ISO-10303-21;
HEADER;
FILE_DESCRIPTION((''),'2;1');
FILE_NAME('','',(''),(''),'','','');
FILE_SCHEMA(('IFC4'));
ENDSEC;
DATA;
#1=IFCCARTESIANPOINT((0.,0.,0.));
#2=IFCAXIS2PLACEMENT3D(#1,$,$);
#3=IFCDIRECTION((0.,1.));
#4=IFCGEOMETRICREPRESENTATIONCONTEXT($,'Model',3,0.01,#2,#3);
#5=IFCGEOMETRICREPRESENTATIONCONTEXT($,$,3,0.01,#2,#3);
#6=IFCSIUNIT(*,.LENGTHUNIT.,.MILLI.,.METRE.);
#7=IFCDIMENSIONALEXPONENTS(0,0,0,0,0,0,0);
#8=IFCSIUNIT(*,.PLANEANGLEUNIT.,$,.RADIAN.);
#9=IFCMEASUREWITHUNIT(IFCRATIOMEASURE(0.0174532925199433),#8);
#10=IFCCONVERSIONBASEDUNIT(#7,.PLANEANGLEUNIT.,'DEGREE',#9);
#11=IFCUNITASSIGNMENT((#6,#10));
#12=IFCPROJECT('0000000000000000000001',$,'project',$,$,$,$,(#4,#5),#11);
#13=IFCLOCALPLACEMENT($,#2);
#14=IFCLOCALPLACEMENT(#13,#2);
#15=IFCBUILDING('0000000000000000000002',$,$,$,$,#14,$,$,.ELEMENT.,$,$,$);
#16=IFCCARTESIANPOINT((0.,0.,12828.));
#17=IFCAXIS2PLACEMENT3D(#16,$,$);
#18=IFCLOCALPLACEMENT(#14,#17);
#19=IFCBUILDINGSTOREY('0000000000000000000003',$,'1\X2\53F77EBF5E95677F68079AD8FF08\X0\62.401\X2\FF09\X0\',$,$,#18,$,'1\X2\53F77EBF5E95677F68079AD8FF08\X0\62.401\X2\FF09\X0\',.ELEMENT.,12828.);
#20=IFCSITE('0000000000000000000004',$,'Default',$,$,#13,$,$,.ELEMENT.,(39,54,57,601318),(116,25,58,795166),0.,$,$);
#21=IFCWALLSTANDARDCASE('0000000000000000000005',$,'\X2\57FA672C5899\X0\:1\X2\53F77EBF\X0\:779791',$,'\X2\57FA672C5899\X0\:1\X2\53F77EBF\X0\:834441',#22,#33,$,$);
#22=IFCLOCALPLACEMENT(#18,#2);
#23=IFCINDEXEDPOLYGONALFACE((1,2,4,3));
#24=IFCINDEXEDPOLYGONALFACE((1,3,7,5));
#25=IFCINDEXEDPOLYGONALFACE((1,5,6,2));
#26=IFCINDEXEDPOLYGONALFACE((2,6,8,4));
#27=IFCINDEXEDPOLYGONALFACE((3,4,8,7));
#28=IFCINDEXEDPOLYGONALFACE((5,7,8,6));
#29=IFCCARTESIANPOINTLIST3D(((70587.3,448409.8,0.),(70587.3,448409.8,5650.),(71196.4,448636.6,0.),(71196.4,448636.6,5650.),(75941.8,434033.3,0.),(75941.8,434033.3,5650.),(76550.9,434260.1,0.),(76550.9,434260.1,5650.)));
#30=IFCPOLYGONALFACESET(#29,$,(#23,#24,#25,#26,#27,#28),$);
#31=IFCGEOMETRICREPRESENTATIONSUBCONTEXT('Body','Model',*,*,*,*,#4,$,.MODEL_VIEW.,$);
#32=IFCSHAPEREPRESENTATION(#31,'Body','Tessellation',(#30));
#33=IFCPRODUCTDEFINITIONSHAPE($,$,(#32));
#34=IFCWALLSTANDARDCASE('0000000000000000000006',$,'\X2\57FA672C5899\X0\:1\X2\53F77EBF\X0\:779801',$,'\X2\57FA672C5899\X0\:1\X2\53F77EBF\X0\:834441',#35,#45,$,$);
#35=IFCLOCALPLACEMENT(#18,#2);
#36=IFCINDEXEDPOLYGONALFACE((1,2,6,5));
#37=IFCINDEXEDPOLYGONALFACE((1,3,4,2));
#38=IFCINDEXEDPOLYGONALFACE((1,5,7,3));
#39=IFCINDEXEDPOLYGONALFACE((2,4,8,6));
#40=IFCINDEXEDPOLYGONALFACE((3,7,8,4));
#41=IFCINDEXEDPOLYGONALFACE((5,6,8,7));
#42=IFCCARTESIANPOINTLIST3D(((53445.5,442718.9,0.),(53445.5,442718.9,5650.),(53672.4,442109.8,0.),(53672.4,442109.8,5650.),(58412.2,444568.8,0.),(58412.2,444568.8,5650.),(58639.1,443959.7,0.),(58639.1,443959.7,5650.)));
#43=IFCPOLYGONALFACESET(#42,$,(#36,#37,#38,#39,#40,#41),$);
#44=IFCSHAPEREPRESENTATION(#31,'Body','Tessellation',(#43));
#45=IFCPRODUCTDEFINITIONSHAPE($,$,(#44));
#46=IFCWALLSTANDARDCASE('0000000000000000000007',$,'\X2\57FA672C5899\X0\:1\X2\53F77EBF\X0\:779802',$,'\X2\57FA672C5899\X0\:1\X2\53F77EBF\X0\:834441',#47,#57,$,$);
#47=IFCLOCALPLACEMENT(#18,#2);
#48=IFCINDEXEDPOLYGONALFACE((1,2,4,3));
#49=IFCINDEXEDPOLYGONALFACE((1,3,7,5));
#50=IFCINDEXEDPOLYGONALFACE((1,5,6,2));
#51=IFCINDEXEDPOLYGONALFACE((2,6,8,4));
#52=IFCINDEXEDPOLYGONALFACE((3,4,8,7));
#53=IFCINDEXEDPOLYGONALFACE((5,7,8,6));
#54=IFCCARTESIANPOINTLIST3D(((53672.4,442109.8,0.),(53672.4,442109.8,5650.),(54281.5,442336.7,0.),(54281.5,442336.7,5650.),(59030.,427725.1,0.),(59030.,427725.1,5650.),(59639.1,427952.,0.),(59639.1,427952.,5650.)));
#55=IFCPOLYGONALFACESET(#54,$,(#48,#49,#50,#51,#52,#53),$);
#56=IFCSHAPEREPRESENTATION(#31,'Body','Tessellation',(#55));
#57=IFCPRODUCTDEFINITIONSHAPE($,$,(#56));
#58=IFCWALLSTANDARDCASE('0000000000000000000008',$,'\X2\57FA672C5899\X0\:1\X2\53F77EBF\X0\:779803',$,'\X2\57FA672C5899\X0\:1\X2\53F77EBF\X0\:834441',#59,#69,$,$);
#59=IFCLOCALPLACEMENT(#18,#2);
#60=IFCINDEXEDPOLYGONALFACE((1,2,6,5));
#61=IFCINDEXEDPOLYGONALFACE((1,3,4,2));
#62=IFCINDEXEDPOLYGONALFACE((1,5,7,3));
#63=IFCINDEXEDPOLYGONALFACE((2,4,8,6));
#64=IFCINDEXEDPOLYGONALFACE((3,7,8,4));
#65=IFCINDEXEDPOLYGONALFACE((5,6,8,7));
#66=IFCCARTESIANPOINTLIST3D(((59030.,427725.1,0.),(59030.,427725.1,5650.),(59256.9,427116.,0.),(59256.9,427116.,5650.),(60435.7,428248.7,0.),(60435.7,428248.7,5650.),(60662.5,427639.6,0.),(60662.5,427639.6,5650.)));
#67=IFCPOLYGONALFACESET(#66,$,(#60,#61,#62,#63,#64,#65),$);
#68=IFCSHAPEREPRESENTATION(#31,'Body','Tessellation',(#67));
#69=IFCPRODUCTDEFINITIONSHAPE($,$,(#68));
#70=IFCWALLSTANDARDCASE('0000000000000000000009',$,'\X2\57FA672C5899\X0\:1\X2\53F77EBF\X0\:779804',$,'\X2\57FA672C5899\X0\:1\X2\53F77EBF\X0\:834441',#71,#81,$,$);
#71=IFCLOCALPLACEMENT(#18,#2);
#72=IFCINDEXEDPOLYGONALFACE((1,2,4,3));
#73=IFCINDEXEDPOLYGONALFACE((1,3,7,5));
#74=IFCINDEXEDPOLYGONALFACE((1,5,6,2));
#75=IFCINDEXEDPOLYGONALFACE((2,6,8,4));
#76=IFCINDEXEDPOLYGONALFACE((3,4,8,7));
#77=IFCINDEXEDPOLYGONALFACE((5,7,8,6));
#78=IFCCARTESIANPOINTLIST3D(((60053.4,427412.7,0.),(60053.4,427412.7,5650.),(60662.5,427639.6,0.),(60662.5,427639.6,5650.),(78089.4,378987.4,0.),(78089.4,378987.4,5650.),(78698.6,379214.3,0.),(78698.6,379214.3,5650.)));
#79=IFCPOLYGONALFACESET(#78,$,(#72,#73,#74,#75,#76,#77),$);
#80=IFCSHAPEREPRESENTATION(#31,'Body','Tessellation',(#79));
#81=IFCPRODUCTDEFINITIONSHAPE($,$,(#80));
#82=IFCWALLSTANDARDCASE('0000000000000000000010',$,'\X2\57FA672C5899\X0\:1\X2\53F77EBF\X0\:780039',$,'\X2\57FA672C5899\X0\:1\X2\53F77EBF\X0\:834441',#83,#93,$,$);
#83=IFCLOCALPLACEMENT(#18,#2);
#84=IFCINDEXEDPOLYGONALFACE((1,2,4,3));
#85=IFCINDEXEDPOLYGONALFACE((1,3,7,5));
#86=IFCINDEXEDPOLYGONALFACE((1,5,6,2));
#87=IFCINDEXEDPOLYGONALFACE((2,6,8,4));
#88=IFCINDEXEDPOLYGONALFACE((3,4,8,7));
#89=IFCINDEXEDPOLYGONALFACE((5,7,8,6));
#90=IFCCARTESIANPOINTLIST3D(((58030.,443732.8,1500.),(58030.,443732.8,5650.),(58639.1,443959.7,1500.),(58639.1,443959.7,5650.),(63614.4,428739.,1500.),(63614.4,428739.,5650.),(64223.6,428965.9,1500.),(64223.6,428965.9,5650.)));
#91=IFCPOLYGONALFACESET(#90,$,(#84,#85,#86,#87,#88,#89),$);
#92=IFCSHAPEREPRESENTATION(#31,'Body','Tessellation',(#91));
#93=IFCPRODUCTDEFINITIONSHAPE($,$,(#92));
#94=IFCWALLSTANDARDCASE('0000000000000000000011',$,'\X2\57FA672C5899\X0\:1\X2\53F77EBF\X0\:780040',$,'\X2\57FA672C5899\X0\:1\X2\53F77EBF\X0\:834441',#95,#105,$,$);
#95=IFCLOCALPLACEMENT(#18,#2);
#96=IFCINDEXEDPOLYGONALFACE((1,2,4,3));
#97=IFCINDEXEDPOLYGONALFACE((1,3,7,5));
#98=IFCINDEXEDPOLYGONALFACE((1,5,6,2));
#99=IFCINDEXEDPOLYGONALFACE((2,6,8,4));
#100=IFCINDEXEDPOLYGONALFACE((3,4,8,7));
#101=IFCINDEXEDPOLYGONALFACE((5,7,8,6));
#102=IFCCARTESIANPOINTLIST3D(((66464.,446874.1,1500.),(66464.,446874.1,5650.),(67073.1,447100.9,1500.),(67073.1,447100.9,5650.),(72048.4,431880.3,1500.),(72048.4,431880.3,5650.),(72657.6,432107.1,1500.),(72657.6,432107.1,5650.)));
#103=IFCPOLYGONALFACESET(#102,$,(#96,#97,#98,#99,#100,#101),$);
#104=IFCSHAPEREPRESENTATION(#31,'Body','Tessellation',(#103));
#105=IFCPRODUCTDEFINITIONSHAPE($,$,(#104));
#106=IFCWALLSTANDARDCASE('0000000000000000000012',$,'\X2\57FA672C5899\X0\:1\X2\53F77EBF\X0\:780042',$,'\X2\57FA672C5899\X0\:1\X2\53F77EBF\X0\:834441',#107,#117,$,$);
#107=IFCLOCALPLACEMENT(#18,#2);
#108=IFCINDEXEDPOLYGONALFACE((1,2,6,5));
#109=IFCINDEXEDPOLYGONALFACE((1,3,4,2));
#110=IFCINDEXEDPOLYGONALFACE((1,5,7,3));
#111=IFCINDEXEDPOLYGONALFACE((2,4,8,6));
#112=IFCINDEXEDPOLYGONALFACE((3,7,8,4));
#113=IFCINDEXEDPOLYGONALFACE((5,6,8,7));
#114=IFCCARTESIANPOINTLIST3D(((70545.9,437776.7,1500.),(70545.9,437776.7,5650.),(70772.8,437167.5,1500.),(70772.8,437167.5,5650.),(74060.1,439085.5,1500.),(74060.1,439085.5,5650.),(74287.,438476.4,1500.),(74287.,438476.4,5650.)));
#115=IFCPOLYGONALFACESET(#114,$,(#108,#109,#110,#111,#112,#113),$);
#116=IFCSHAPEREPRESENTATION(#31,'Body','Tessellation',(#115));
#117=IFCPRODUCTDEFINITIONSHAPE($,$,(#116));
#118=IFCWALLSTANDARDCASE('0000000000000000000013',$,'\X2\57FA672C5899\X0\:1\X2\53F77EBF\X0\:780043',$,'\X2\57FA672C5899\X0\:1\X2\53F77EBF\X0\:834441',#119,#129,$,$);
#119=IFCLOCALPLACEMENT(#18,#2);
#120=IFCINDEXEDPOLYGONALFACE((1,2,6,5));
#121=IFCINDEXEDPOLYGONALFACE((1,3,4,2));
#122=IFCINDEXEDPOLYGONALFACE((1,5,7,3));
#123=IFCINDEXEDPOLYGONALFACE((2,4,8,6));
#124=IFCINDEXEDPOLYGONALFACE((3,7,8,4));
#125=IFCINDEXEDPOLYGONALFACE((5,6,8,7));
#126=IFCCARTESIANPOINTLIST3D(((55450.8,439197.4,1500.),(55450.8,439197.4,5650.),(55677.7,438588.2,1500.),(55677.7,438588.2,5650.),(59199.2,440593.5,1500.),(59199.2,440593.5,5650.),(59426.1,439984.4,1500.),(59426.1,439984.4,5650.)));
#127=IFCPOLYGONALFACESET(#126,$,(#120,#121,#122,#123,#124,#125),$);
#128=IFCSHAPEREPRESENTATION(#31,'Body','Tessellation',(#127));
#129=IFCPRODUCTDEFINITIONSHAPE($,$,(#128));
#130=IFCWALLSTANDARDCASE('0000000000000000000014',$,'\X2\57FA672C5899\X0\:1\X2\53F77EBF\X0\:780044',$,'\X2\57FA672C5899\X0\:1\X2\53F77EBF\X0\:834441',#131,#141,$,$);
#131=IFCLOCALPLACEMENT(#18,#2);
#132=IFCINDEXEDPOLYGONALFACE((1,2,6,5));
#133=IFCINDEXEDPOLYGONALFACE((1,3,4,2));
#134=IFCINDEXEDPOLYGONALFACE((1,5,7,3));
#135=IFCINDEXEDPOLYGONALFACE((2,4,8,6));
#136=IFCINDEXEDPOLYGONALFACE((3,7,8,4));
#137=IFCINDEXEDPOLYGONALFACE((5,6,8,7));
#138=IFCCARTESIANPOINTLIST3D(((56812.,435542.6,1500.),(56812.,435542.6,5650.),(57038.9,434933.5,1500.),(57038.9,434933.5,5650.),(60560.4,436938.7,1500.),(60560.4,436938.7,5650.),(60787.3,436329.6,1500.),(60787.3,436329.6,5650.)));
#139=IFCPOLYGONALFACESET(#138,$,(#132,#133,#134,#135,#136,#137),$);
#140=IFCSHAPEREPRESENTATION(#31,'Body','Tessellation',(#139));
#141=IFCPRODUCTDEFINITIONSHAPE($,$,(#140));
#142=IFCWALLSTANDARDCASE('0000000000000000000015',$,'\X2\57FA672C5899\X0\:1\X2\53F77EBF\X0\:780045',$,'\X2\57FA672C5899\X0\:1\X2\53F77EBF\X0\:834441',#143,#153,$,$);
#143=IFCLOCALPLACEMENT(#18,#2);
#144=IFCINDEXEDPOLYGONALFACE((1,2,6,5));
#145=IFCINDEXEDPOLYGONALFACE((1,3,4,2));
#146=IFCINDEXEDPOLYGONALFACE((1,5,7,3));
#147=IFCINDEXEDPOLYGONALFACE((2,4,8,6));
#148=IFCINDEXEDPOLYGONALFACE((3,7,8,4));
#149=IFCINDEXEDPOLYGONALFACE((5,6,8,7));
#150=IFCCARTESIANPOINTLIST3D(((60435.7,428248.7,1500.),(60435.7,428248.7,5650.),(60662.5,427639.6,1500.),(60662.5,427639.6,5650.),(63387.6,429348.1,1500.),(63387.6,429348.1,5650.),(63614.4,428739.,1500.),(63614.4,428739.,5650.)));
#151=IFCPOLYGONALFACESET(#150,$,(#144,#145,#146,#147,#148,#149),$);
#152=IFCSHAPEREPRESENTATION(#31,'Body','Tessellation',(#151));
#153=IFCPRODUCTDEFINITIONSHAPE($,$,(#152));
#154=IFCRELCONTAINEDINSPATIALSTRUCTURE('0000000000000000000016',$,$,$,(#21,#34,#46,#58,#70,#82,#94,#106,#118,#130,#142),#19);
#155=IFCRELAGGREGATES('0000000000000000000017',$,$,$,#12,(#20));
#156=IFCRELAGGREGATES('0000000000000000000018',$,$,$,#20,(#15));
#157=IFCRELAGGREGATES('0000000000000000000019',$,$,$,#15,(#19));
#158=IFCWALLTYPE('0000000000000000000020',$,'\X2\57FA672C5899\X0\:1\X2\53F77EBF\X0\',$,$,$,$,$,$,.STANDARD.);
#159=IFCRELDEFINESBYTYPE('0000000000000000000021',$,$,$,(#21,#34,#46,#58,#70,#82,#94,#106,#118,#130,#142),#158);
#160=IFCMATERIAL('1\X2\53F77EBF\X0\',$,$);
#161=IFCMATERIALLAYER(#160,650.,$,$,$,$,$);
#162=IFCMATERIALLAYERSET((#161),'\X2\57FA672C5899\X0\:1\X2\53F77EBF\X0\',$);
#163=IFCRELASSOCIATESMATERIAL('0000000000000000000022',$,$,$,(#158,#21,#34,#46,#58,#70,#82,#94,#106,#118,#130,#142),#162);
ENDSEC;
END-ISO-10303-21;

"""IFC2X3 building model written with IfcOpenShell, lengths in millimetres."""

from ifc_helpers import new_model, entity, si_unit, converted_unit, direction, frame, frame_2d, origin, place, context, subcontext, project, spatial, polyline, rectangle, extrude, clip, bounded_halfspace, material, layer, layer_set, layer_usage, type_object, element, save


model = new_model("IFC2X3")

# Units and contexts
model_context = context("Model", 3, precision=0.01, world=origin(), true_north=direction((0.0, 1.0)))
context_of_model = context(None, 3, precision=0.01, world=origin(), true_north=direction((0.0, 1.0)))
body_context = subcontext(model_context, "Body", "Model", "MODEL_VIEW")
ifc_project = project(units=[si_unit("LENGTHUNIT", "METRE", prefix="MILLI"), converted_unit("PLANEANGLEUNIT", "DEGREE", entity("IfcRatioMeasure", 0.0174532925199433), si_unit("PLANEANGLEUNIT", "RADIAN"), dimensions=[0, 0, 0, 0, 0, 0, 0])], contexts=[model_context, context_of_model])

# Site, building, storey
site_placement = place(None, origin())
site = spatial("IfcSite", under=ifc_project, at=site_placement, Name="Default", CompositionType="ELEMENT", RefLatitude=(39, 54, 57, 601318), RefLongitude=(116, 25, 58, 795166), RefElevation=0.0)
building_placement = place(site_placement, origin())
building = spatial("IfcBuilding", under=site, at=building_placement, CompositionType="ELEMENT")
storey_placement = place(building_placement, frame((0.0, 0.0, 12828.0)))
storey = spatial("IfcBuildingStorey", under=building, at=storey_placement, Name="1号线底板标高（62.401）", LongName="1号线底板标高（62.401）", CompositionType="ELEMENT", Elevation=12828.0)

# Walls
ifc_material_1 = material(Name="1号线")
ifc_layer_1 = layer(ifc_material_1, 650.0)
ifc_layer_set_1 = layer_set([ifc_layer_1], Name="基本墙:1号线")
wall_type = type_object("IfcWallType", Name="基本墙:1号线", PredefinedType="STANDARD", material=ifc_layer_set_1)
ifc_layer_usage_1 = layer_usage(ifc_layer_set_1, "AXIS2", "NEGATIVE", 325.0)
wall_1_placement = place(storey_placement, frame((70891.9, 448523.2, 0.0), z_axis=(0.0, 0.0, 1.0), x_axis=(0.349028, -0.937112, 0.0)))
element("IfcWallStandardCase", 1, at=wall_1_placement, inside=storey, type_object=wall_type, material=ifc_layer_usage_1, Name="基本墙:1号线:779791", ObjectType="基本墙:1号线:834441", context=body_context, shape_type="Clipping", body=[
    clip(extrude(rectangle(XDim=15341.3, YDim=650.0, at=frame_2d((7670.6, 0.0), x_axis=(-1.0, 0.0))), origin(), (0.0, 0.0, 1.0), 5650.0), bounded_halfspace(frame((0.0, -325.0, 5650.0), z_axis=(0.0, 0.0, -1.0), x_axis=(0.0, 1.0, 0.0)), True, frame((0.0, -325.0, 5650.0)), polyline([(0.0, 0.0), (9950.0, 0.0), (10600.0, 0.0), (15341.3, 0.0), (15341.3, 650.0), (0.0, 650.0), (0.0, 0.0)]))),
])
ifc_layer_usage_2 = layer_usage(ifc_layer_set_1, "AXIS2", "NEGATIVE", 325.0)
wall_2_placement = place(storey_placement, frame((58525.7, 444264.2, 0.0), z_axis=(0.0, 0.0, 1.0), x_axis=(-0.937112, -0.349028, 0.0)))
element("IfcWallStandardCase", 2, at=wall_2_placement, inside=storey, type_object=wall_type, material=ifc_layer_usage_2, Name="基本墙:1号线:779801", ObjectType="基本墙:1号线:834441", context=body_context, shape_type="Clipping", body=[
    clip(extrude(rectangle(XDim=5300.0, YDim=650.0, at=frame_2d((2650.0, 0.0), x_axis=(-1.0, 0.0))), origin(), (0.0, 0.0, 1.0), 5650.0), bounded_halfspace(frame((0.0, -325.0, 5650.0), z_axis=(0.0, 0.0, -1.0), x_axis=(-1.0, 0.0, 0.0)), True, frame((0.0, -325.0, 5650.0)), polyline([(0.0, 0.0), (1950.5, 0.0), (5300.0, 0.0), (5300.0, 650.0), (4650.0, 650.0), (650.0, 650.0), (0.0, 650.0), (0.0, 0.0)]))),
])
ifc_layer_usage_3 = layer_usage(ifc_layer_set_1, "AXIS2", "NEGATIVE", 325.0)
wall_3_placement = place(storey_placement, frame((53977.0, 442223.3, 0.0), z_axis=(0.0, 0.0, 1.0), x_axis=(0.349028, -0.937112, 0.0)))
element("IfcWallStandardCase", 3, at=wall_3_placement, inside=storey, type_object=wall_type, material=ifc_layer_usage_3, Name="基本墙:1号线:779802", ObjectType="基本墙:1号线:834441", context=body_context, shape_type="Clipping", body=[
    clip(extrude(rectangle(XDim=15350.0, YDim=650.0, at=frame_2d((7675.0, 0.0), x_axis=(-1.0, 0.0))), origin(), (0.0, 0.0, 1.0), 5650.0), bounded_halfspace(frame((0.0, -325.0, 5650.0), z_axis=(0.0, 0.0, -1.0), x_axis=(0.0, 1.0, 0.0)), True, frame((0.0, -325.0, 5650.0)), polyline([(0.0, 0.0), (15350.0, 0.0), (15350.0, 650.0), (7900.0, 650.0), (7250.0, 650.0), (4000.0, 650.0), (3350.0, 650.0), (0.0, 650.0), (0.0, 0.0)]))),
])
ifc_layer_usage_4 = layer_usage(ifc_layer_set_1, "AXIS2", "NEGATIVE", 325.0)
wall_4_placement = place(storey_placement, frame((59143.4, 427420.6, 0.0), z_axis=(0.0, 0.0, 1.0), x_axis=(0.937112, 0.349028, 0.0)))
element("IfcWallStandardCase", 4, at=wall_4_placement, inside=storey, type_object=wall_type, material=ifc_layer_usage_4, Name="基本墙:1号线:779803", ObjectType="基本墙:1号线:834441", context=body_context, shape_type="Clipping", body=[
    clip(extrude(rectangle(XDim=1500.0, YDim=650.0, at=frame_2d((750.0, 0.0), x_axis=(-1.0, 0.0))), origin(), (0.0, 0.0, 1.0), 5650.0), bounded_halfspace(frame((0.0, -325.0, 5650.0), z_axis=(0.0, 0.0, -1.0), x_axis=(1.0, 0.0, 0.0)), True, frame((0.0, -325.0, 5650.0)), polyline([(0.0, 0.0), (650.0, 0.0), (850.0, 0.0), (1500.0, 0.0), (1500.0, 650.0), (650.0, 650.0), (0.0, 650.0), (0.0, 0.0)]))),
])
ifc_layer_usage_5 = layer_usage(ifc_layer_set_1, "AXIS2", "NEGATIVE", 325.0)
wall_5_placement = place(storey_placement, frame((60358.0, 427526.1, 0.0), z_axis=(0.0, 0.0, 1.0), x_axis=(0.349028, -0.937112, 0.0)))
element("IfcWallStandardCase", 5, at=wall_5_placement, inside=storey, type_object=wall_type, material=ifc_layer_usage_5, Name="基本墙:1号线:779804", ObjectType="基本墙:1号线:834441", context=body_context, shape_type="Clipping", body=[
    clip(extrude(rectangle(XDim=51675.0, YDim=650.0, at=frame_2d((25837.5, 0.0), x_axis=(-1.0, 0.0))), origin(), (0.0, 0.0, 1.0), 5650.0), bounded_halfspace(frame((0.0, -325.0, 5650.0), z_axis=(0.0, 0.0, -1.0), x_axis=(0.0, 1.0, 0.0)), True, frame((0.0, -325.0, 5650.0)), polyline([(0.0, 0.0), (200.0, 0.0), (50867.2, 0.0), (51023.8, 0.0), (51021.9, 650.0), (0.0, 650.0), (0.0, 0.0)]))),
])
ifc_layer_usage_6 = layer_usage(ifc_layer_set_1, "AXIS2", "NEGATIVE", 325.0)
wall_6_placement = place(storey_placement, frame((58334.5, 443846.2, 1500.0), z_axis=(0.0, 0.0, 1.0), x_axis=(0.349028, -0.937112, 0.0)))
element("IfcWallStandardCase", 6, at=wall_6_placement, inside=storey, type_object=wall_type, material=ifc_layer_usage_6, Name="基本墙:1号线:780039", ObjectType="基本墙:1号线:834441", context=body_context, shape_type="Clipping", body=[
    clip(extrude(rectangle(XDim=16000.0, YDim=650.0, at=frame_2d((8000.0, 0.0), x_axis=(-1.0, 0.0))), origin(), (0.0, 0.0, 1.0), 4150.0), bounded_halfspace(frame((0.0, -325.0, 4150.0), z_axis=(0.0, 0.0, -1.0), x_axis=(0.0, 1.0, 0.0)), True, frame((0.0, -325.0, 4150.0)), polyline([(0.0, 0.0), (3350.0, 0.0), (4000.0, 0.0), (7250.0, 0.0), (7900.0, 0.0), (15350.0, 0.0), (16000.0, 0.0), (16000.0, 650.0), (0.0, 650.0), (0.0, 0.0)]))),
])
ifc_layer_usage_7 = layer_usage(ifc_layer_set_1, "AXIS2", "NEGATIVE", 325.0)
wall_7_placement = place(storey_placement, frame((66768.6, 446987.5, 1500.0), z_axis=(0.0, 0.0, 1.0), x_axis=(0.349028, -0.937112, 0.0)))
element("IfcWallStandardCase", 7, at=wall_7_placement, inside=storey, type_object=wall_type, material=ifc_layer_usage_7, Name="基本墙:1号线:780040", ObjectType="基本墙:1号线:834441", context=body_context, shape_type="Clipping", body=[
    clip(extrude(rectangle(XDim=16000.0, YDim=650.0, at=frame_2d((8000.0, 0.0), x_axis=(-1.0, 0.0))), origin(), (0.0, 0.0, 1.0), 4150.0), bounded_halfspace(frame((0.0, -325.0, 4150.0), z_axis=(0.0, 0.0, -1.0), x_axis=(0.0, 1.0, 0.0)), True, frame((0.0, -325.0, 4150.0)), polyline([(0.0, 0.0), (16000.0, 0.0), (16000.0, 650.0), (15350.0, 650.0), (10600.0, 650.0), (9950.0, 650.0), (0.0, 650.0), (0.0, 0.0)]))),
])
ifc_layer_usage_8 = layer_usage(ifc_layer_set_1, "AXIS2", "NEGATIVE", 325.0)
wall_8_placement = place(storey_placement, frame((70659.4, 437472.1, 1500.0), z_axis=(0.0, 0.0, 1.0), x_axis=(0.937112, 0.349028, 0.0)))
element("IfcWallStandardCase", 8, at=wall_8_placement, inside=storey, type_object=wall_type, material=ifc_layer_usage_8, Name="基本墙:1号线:780042", ObjectType="基本墙:1号线:834441", context=body_context, shape_type="Clipping", body=[
    clip(extrude(rectangle(XDim=3750.0, YDim=650.0, at=frame_2d((1875.0, 0.0), x_axis=(-1.0, 0.0))), origin(), (0.0, 0.0, 1.0), 4150.0), bounded_halfspace(frame((0.0, -325.0, 4150.0), z_axis=(0.0, 0.0, -1.0), x_axis=(1.0, 0.0, 0.0)), True, frame((0.0, -325.0, 4150.0)), polyline([(0.0, 0.0), (3750.0, 0.0), (3750.0, 650.0), (0.0, 650.0), (0.0, 0.0)]))),
])
ifc_layer_usage_9 = layer_usage(ifc_layer_set_1, "AXIS2", "NEGATIVE", 325.0)
wall_9_placement = place(storey_placement, frame((55564.2, 438892.8, 1500.0), z_axis=(0.0, 0.0, 1.0), x_axis=(0.937112, 0.349028, 0.0)))
element("IfcWallStandardCase", 9, at=wall_9_placement, inside=storey, type_object=wall_type, material=ifc_layer_usage_9, Name="基本墙:1号线:780043", ObjectType="基本墙:1号线:834441", context=body_context, shape_type="Clipping", body=[
    clip(extrude(rectangle(XDim=4000.0, YDim=650.0, at=frame_2d((2000.0, 0.0), x_axis=(-1.0, 0.0))), origin(), (0.0, 0.0, 1.0), 4150.0), bounded_halfspace(frame((0.0, -325.0, 4150.0), z_axis=(0.0, 0.0, -1.0), x_axis=(1.0, 0.0, 0.0)), True, frame((0.0, -325.0, 4150.0)), polyline([(0.0, 0.0), (4000.0, 0.0), (4000.0, 650.0), (0.0, 650.0), (0.0, 0.0)]))),
])
ifc_layer_usage_10 = layer_usage(ifc_layer_set_1, "AXIS2", "NEGATIVE", 325.0)
wall_10_placement = place(storey_placement, frame((56925.4, 435238.1, 1500.0), z_axis=(0.0, 0.0, 1.0), x_axis=(0.937112, 0.349028, 0.0)))
element("IfcWallStandardCase", 10, at=wall_10_placement, inside=storey, type_object=wall_type, material=ifc_layer_usage_10, Name="基本墙:1号线:780044", ObjectType="基本墙:1号线:834441", context=body_context, shape_type="Clipping", body=[
    clip(extrude(rectangle(XDim=4000.0, YDim=650.0, at=frame_2d((2000.0, 0.0), x_axis=(-1.0, 0.0))), origin(), (0.0, 0.0, 1.0), 4150.0), bounded_halfspace(frame((0.0, -325.0, 4150.0), z_axis=(0.0, 0.0, -1.0), x_axis=(1.0, 0.0, 0.0)), True, frame((0.0, -325.0, 4150.0)), polyline([(0.0, 0.0), (4000.0, 0.0), (4000.0, 650.0), (0.0, 650.0), (0.0, 0.0)]))),
])
ifc_layer_usage_11 = layer_usage(ifc_layer_set_1, "AXIS2", "NEGATIVE", 325.0)
wall_11_placement = place(storey_placement, frame((60549.1, 427944.1, 1500.0), z_axis=(0.0, 0.0, 1.0), x_axis=(0.937112, 0.349028, 0.0)))
element("IfcWallStandardCase", 11, at=wall_11_placement, inside=storey, type_object=wall_type, material=ifc_layer_usage_11, Name="基本墙:1号线:780045", ObjectType="基本墙:1号线:834441", context=body_context, shape_type="Clipping", body=[
    clip(extrude(rectangle(XDim=3150.0, YDim=650.0, at=frame_2d((1575.0, 0.0), x_axis=(-1.0, 0.0))), origin(), (0.0, 0.0, 1.0), 4150.0), bounded_halfspace(frame((0.0, -325.0, 4150.0), z_axis=(0.0, 0.0, -1.0), x_axis=(1.0, 0.0, 0.0)), True, frame((0.0, -325.0, 4150.0)), polyline([(0.0, 0.0), (3150.0, 0.0), (3150.0, 650.0), (0.0, 650.0), (0.0, 0.0)]))),
])

save(model, "model.ifc")
